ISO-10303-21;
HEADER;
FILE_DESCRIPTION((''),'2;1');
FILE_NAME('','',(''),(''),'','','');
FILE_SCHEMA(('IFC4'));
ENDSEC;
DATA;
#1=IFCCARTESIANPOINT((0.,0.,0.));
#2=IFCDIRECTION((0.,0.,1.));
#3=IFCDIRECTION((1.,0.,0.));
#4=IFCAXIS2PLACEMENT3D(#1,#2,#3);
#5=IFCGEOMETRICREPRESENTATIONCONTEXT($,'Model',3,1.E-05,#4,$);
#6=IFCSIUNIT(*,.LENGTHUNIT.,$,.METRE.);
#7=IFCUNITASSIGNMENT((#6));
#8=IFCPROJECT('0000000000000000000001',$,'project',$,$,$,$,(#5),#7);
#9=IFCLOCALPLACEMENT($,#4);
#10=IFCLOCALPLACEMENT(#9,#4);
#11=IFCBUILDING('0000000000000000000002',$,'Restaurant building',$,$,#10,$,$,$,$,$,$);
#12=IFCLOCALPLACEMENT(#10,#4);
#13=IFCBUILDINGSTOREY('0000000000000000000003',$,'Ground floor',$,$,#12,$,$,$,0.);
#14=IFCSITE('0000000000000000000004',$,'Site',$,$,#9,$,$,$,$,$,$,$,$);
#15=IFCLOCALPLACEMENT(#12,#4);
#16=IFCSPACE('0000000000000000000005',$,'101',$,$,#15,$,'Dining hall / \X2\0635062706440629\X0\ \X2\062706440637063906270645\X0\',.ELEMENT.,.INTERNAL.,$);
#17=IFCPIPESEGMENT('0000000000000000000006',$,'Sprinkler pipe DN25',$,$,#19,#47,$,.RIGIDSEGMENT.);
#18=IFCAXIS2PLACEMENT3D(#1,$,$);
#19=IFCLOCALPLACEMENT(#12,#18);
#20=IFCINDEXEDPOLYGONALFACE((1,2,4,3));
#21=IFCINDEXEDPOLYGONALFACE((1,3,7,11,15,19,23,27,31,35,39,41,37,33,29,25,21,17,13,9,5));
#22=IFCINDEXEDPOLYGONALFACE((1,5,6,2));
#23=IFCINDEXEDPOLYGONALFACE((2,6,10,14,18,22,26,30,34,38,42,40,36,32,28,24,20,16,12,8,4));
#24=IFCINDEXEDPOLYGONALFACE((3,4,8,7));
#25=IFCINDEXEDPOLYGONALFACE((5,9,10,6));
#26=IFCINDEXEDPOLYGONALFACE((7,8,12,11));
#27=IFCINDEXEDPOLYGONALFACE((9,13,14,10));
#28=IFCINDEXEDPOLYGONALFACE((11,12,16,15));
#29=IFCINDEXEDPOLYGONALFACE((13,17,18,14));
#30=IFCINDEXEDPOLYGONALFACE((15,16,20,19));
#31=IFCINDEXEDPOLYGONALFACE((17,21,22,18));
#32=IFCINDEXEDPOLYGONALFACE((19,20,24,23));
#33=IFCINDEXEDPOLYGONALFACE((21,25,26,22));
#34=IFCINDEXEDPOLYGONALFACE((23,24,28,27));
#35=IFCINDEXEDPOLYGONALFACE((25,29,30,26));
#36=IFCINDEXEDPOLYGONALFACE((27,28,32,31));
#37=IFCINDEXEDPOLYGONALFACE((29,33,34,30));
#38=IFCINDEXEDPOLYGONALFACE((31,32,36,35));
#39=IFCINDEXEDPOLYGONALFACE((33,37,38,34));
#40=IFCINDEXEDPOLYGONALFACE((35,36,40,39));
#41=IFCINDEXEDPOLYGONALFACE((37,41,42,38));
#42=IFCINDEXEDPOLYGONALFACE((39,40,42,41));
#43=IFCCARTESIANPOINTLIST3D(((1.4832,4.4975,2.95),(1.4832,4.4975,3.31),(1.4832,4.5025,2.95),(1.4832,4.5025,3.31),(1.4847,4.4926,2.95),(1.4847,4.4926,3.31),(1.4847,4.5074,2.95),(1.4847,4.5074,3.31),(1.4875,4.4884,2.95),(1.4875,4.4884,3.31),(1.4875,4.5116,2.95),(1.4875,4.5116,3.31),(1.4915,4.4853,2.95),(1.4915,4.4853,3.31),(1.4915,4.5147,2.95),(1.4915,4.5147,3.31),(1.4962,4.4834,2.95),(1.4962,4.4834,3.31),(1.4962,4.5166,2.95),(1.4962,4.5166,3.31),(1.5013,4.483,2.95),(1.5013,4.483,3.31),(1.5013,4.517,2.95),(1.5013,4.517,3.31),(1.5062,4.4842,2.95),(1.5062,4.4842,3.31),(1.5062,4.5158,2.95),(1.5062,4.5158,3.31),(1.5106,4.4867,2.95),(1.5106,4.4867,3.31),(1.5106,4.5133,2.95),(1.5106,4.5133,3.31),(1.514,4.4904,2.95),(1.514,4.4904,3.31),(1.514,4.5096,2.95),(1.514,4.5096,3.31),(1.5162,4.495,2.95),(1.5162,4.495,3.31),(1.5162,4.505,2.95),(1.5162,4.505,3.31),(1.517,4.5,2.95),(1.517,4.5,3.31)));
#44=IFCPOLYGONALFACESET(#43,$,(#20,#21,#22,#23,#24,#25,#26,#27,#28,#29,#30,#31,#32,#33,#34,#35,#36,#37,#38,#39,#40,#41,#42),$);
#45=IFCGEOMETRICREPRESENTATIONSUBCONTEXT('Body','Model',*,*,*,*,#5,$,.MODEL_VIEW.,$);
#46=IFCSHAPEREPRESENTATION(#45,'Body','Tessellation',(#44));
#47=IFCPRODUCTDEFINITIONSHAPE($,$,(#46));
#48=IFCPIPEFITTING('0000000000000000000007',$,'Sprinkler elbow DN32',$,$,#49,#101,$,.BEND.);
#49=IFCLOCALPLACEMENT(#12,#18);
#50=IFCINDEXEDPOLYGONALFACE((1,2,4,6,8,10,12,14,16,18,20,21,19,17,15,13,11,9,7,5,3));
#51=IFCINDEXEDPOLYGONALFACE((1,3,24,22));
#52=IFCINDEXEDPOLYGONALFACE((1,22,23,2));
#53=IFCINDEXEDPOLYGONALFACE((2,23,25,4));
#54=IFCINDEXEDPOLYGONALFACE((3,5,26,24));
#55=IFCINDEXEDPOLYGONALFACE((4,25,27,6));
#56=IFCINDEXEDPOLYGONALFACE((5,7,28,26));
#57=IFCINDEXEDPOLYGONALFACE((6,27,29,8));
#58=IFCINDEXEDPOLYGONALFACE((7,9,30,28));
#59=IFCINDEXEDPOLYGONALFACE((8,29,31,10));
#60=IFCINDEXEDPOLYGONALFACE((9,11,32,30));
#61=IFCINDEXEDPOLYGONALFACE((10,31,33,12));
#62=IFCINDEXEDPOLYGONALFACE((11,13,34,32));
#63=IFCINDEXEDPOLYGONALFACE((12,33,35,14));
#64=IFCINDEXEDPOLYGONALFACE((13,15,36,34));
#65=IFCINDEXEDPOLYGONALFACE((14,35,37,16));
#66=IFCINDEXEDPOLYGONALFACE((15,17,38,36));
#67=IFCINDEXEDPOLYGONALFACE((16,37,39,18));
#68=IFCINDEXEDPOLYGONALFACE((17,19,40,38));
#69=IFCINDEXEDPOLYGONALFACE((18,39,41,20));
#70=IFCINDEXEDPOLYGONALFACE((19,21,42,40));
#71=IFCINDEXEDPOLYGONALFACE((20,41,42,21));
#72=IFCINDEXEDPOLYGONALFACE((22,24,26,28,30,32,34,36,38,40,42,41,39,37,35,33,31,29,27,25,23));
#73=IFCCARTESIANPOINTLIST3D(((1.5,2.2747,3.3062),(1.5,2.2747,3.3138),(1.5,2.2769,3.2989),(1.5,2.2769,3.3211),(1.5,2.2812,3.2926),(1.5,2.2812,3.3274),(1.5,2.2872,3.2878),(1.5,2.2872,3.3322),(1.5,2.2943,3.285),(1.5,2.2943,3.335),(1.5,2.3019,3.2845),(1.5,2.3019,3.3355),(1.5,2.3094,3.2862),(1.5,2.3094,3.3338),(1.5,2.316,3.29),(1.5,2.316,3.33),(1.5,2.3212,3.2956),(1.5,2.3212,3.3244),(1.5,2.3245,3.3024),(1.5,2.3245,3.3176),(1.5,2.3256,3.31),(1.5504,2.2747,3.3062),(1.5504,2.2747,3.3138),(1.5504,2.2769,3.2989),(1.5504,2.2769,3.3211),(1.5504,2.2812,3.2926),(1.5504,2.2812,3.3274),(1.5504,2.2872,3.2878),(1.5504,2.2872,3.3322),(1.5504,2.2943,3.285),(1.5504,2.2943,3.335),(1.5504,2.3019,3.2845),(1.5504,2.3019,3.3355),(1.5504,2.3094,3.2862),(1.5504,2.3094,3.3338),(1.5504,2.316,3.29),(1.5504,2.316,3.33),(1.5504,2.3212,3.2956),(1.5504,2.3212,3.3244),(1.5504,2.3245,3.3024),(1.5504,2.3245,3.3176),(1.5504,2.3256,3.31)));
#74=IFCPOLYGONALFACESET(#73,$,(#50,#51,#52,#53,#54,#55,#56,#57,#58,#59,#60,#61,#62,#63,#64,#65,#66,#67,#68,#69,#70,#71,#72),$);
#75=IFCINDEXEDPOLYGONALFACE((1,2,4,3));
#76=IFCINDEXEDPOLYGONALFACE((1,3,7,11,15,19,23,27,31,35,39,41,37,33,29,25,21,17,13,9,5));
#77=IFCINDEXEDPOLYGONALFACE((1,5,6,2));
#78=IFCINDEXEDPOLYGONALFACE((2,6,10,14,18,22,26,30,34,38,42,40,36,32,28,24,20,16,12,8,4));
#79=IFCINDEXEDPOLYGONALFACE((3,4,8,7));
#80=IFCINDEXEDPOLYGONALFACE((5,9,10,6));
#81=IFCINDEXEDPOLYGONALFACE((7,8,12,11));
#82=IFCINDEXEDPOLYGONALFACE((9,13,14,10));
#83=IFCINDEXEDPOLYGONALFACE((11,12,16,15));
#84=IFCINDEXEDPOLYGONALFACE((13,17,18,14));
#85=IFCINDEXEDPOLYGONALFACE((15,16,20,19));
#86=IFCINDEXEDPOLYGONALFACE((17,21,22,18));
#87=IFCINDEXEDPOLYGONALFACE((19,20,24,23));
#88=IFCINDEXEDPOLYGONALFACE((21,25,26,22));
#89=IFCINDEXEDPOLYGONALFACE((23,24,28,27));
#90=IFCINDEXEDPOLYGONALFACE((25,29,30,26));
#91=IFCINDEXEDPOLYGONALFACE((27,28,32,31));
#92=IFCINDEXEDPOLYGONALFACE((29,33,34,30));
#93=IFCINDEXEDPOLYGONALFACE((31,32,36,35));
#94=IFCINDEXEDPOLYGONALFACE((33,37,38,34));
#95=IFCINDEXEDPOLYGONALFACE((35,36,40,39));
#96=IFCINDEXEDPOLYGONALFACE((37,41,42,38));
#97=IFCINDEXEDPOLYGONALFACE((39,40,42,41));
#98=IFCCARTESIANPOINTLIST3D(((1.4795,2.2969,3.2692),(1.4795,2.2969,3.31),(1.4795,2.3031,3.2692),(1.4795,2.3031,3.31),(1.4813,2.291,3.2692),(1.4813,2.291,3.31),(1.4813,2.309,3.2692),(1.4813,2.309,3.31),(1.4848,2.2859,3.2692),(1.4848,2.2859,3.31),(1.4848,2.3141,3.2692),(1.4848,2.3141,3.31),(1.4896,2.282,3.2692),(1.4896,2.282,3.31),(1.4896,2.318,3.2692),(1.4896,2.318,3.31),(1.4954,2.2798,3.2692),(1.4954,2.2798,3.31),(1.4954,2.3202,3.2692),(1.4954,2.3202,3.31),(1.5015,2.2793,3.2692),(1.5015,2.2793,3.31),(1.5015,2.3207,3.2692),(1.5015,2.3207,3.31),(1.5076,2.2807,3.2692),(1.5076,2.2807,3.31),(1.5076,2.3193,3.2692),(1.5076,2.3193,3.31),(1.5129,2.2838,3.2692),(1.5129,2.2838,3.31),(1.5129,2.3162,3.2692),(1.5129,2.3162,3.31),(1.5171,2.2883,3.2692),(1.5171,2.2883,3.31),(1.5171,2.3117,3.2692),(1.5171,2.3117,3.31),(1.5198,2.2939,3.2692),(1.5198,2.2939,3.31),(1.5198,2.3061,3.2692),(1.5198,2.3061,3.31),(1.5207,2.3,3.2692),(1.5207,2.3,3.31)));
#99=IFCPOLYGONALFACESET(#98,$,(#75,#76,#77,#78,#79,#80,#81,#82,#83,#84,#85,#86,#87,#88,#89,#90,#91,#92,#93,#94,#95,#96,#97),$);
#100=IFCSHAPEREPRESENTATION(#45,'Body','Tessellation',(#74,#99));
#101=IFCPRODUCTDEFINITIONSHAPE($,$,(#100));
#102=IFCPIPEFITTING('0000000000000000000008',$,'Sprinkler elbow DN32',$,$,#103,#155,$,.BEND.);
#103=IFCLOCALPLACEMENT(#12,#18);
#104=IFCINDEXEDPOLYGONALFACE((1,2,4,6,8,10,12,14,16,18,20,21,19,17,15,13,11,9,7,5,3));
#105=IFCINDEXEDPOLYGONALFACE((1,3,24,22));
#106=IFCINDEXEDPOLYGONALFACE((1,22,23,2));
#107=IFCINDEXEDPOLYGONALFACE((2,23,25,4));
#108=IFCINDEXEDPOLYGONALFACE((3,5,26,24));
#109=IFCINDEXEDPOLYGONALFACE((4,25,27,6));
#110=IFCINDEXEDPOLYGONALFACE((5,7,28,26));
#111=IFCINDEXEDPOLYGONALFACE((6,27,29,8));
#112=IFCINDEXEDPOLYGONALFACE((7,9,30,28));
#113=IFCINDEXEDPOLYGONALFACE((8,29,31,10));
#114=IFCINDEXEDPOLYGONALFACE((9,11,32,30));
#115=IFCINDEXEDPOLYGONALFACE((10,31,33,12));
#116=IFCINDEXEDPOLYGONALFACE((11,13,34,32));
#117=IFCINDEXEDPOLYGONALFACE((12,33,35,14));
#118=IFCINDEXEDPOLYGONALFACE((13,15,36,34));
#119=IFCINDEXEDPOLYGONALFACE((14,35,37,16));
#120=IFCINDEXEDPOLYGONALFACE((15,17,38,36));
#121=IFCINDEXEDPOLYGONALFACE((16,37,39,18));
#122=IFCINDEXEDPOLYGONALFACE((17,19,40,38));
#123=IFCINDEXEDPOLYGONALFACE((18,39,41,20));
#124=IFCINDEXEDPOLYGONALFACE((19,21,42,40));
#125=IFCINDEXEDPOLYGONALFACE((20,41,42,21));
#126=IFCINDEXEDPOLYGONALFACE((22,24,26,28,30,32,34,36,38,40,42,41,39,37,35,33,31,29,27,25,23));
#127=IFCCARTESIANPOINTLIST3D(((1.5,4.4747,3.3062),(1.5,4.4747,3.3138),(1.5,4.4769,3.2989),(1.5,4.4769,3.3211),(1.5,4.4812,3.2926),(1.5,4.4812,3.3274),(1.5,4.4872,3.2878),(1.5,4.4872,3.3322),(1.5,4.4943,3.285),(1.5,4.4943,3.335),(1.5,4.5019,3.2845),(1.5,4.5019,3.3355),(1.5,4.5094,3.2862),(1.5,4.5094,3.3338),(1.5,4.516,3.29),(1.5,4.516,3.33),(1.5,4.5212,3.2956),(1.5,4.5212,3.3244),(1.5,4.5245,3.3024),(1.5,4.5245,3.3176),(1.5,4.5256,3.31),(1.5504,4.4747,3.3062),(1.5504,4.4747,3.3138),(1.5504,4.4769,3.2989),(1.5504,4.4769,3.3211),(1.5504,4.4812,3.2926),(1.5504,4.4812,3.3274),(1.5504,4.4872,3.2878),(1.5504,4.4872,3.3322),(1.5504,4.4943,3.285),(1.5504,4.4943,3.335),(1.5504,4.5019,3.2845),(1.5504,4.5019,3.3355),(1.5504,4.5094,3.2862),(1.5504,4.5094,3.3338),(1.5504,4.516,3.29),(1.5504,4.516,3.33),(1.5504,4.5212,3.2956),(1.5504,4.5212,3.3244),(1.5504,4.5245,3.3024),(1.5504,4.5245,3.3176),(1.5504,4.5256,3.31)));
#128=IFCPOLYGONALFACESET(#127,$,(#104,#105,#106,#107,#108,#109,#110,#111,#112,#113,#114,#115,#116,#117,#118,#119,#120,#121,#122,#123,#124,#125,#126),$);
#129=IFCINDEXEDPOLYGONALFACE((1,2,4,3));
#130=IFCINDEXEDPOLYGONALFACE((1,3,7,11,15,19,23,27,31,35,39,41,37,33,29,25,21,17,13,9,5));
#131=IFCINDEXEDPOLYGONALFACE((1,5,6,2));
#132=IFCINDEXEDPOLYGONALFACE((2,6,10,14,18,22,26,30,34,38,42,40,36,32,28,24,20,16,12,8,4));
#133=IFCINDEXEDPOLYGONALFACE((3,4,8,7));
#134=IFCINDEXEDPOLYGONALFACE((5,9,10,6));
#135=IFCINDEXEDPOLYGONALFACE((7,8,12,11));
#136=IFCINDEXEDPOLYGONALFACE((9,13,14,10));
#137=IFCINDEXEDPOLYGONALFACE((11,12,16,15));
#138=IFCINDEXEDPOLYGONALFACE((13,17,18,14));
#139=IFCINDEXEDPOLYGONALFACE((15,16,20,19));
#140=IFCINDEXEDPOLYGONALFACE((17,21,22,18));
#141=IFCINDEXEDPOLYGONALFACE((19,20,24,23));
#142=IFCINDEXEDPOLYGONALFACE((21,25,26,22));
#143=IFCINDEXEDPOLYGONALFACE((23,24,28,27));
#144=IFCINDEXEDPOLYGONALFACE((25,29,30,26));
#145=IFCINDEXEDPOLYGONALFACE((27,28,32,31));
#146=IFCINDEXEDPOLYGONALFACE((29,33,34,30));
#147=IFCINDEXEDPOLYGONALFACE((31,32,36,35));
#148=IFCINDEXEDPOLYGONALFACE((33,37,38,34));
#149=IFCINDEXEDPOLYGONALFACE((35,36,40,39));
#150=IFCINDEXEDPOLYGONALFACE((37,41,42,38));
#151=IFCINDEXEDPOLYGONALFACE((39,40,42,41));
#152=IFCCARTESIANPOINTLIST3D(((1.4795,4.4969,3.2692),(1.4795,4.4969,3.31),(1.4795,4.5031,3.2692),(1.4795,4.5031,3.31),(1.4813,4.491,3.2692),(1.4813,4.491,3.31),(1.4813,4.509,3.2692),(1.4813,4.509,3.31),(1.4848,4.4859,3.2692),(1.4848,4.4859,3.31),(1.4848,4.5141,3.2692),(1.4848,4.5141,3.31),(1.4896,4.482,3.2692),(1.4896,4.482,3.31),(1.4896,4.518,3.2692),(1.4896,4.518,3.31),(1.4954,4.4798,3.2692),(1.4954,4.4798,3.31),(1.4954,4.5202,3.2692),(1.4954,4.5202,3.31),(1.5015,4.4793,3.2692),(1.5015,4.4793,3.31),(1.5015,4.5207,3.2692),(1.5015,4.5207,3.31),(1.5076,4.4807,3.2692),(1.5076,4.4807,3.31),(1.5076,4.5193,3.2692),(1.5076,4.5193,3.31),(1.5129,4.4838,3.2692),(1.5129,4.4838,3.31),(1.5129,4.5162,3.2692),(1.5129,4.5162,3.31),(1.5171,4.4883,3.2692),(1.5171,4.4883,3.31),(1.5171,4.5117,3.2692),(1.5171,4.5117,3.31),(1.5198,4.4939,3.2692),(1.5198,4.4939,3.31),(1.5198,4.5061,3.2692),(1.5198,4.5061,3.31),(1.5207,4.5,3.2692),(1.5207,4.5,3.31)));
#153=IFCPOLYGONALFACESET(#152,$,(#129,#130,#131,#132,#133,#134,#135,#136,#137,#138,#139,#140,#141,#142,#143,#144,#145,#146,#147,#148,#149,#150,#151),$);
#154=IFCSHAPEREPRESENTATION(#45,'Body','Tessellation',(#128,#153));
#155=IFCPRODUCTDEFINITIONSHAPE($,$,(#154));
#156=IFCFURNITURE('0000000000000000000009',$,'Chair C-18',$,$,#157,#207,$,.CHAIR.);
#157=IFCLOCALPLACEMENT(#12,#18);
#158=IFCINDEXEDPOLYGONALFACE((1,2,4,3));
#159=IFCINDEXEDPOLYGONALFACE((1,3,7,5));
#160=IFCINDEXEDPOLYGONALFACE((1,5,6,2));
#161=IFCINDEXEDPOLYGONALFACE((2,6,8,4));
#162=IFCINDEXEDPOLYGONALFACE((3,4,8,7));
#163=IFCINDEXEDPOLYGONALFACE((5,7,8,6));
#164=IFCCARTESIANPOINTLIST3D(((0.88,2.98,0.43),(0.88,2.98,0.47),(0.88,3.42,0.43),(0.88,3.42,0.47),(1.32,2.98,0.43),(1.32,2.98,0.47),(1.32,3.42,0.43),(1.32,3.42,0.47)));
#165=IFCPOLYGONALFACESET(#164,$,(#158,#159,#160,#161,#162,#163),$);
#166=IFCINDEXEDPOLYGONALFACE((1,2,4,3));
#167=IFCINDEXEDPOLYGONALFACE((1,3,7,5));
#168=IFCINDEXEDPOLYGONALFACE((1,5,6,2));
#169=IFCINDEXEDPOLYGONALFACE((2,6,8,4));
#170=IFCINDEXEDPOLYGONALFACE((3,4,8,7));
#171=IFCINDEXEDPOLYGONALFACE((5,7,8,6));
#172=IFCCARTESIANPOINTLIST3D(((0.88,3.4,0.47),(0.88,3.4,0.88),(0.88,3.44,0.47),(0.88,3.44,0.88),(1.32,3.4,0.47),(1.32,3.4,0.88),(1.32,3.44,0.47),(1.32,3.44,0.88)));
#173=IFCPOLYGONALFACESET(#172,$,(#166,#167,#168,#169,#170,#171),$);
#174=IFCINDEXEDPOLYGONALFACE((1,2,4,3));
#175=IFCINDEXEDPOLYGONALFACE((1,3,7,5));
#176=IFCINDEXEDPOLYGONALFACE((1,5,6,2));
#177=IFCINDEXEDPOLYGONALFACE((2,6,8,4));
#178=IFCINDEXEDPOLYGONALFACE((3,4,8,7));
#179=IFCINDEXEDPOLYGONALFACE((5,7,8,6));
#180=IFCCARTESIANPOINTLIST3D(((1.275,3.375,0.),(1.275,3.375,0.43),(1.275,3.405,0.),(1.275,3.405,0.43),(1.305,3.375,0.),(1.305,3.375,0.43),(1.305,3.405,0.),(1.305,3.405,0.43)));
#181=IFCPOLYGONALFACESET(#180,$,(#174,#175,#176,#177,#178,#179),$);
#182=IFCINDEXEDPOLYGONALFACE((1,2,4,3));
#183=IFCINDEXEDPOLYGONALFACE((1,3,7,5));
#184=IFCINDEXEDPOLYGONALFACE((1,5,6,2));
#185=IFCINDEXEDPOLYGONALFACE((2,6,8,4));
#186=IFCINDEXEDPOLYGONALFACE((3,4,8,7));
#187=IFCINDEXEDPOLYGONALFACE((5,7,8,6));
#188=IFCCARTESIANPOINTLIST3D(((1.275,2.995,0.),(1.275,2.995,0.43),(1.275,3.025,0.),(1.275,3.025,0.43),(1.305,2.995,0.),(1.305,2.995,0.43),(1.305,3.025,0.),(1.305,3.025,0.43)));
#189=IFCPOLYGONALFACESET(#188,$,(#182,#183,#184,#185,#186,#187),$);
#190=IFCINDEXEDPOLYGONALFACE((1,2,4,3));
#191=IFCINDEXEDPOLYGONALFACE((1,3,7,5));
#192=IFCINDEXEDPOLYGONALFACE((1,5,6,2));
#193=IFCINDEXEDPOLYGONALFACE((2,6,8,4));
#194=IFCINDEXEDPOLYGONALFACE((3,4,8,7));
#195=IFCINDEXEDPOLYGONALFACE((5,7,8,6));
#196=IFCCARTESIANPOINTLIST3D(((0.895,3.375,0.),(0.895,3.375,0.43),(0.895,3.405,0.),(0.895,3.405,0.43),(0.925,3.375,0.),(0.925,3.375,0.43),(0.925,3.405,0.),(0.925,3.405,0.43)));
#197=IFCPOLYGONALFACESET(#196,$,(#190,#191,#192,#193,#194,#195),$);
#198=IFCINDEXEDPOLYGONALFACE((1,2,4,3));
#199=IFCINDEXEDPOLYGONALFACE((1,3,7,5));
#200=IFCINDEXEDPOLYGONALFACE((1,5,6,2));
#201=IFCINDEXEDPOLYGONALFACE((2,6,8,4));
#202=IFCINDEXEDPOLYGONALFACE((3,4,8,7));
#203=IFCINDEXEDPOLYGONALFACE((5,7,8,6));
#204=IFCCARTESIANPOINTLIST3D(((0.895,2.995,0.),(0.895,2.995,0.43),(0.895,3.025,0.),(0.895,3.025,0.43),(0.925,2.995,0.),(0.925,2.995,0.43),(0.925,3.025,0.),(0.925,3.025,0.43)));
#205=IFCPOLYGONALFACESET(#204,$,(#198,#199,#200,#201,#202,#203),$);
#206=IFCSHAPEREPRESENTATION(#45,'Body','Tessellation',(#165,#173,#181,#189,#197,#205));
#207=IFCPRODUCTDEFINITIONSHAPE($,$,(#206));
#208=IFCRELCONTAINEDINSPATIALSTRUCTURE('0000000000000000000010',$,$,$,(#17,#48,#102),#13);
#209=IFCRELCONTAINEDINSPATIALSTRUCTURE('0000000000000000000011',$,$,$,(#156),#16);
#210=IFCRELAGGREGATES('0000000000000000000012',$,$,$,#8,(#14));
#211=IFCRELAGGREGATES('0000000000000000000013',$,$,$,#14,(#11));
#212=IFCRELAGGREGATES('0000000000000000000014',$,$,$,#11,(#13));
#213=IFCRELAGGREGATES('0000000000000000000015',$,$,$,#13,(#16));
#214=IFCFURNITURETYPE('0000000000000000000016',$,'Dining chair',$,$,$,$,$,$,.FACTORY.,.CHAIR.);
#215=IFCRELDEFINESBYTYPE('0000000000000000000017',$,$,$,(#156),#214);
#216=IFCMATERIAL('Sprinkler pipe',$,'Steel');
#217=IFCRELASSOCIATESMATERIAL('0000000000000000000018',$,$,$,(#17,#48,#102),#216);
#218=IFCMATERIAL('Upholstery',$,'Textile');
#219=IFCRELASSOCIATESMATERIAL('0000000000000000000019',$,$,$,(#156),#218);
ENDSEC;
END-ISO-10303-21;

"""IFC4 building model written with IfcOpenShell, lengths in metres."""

from ifc_helpers import new_model, si_unit, frame, origin, origin_with_axes, origin_2d, place, context, subcontext, project, spatial, rectangle, circle, extrude, source, transform, mapped, material, type_object, type_shapes, element, save


model = new_model("IFC4")

# Units and contexts
model_context = context("Model", 3, precision=1e-05, world=origin_with_axes())
body_context = subcontext(model_context, "Body", "Model", "MODEL_VIEW")
ifc_project = project(units=[si_unit("LENGTHUNIT", "METRE")], contexts=[model_context])

# Site, building, storey
site_placement = place(None, origin_with_axes())
site = spatial("IfcSite", under=ifc_project, at=site_placement, Name="Site")
building_placement = place(site_placement, origin_with_axes())
building = spatial("IfcBuilding", under=site, at=building_placement, Name="Restaurant building")
storey_placement = place(building_placement, origin_with_axes())
storey = spatial("IfcBuildingStorey", under=building, at=storey_placement, Name="Ground floor", Elevation=0.0)

# Shared definitions
space_placement = place(storey_placement, origin_with_axes())
space = spatial("IfcSpace", under=storey, at=space_placement, Name="101", LongName="Dining hall / صالة الطعام", CompositionType="ELEMENT", PredefinedType="INTERNAL")

# Pipe segment
ifc_material_1 = material(Name="Sprinkler pipe", Category="Steel")
for number, where, name in (
    (1, (1.5, 4.5, 3.31), "Sprinkler pipe DN25"),
):
    element("IfcPipeSegment", number, at=place(storey_placement, frame(where)), inside=storey, material=ifc_material_1, Name=name, PredefinedType="RIGIDSEGMENT", context=body_context, shape_type="SweptSolid", body=[
        extrude(circle(Radius=0.017, at=origin_2d()), frame((0.0, 0.0, 0.0), z_axis=(0.0, 0.0, -1.0), x_axis=(1.0, 0.0, 0.0)), (0.0, 0.0, 1.0), 0.36),
    ])

# Pipe fittings
for number, where, name in (
    (2, (1.5, 2.3, 3.31), "Sprinkler elbow DN32"),
    (3, (1.5, 4.5, 3.31), "Sprinkler elbow DN32"),
):
    element("IfcPipeFitting", number, at=place(storey_placement, frame(where)), inside=storey, material=ifc_material_1, Name=name, PredefinedType="BEND", context=body_context, shape_type="SweptSolid", body=[
        extrude(circle(Radius=0.0256, at=origin_2d()), frame((0.0, 0.0, 0.0), z_axis=(1.0, 0.0, 0.0), x_axis=(0.0, 1.0, 0.0)), (0.0, 0.0, 1.0), 0.0504),
        extrude(circle(Radius=0.0207, at=origin_2d()), frame((0.0, 0.0, 0.0), z_axis=(0.0, 0.0, -1.0), x_axis=(1.0, 0.0, 0.0)), (0.0, 0.0, 1.0), 0.0408),
    ])

# Furniture
ifc_material_2 = material(Name="Upholstery", Category="Textile")
furniture_type_1 = type_object("IfcFurnitureType", Name="Dining chair", AssemblyPlace="FACTORY", PredefinedType="CHAIR")
shared_shape_1 = source(origin(), body_context, "Body", "SweptSolid", [
    extrude(rectangle(XDim=0.44, YDim=0.44, at=origin_2d()), frame((0.0, 0.0, 0.43)), (0.0, 0.0, 1.0), 0.04),
    extrude(rectangle(XDim=0.44, YDim=0.04, at=origin_2d()), frame((0.0, -0.22, 0.47)), (0.0, 0.0, 1.0), 0.41),
    extrude(rectangle(XDim=0.03, YDim=0.03, at=origin_2d()), frame((-0.19, -0.19, 0.0)), (0.0, 0.0, 1.0), 0.43),
    extrude(rectangle(XDim=0.03, YDim=0.03, at=origin_2d()), frame((-0.19, 0.19, 0.0)), (0.0, 0.0, 1.0), 0.43),
    extrude(rectangle(XDim=0.03, YDim=0.03, at=origin_2d()), frame((0.19, -0.19, 0.0)), (0.0, 0.0, 1.0), 0.43),
    extrude(rectangle(XDim=0.03, YDim=0.03, at=origin_2d()), frame((0.19, 0.19, 0.0)), (0.0, 0.0, 1.0), 0.43),
])
type_shapes(furniture_type_1, [shared_shape_1])
for number, where, z_axis, x_axis, name in (
    (4, (1.1, 3.2, 0.0), (0.0, 0.0, 1.0), (-1.0, 0.0, 0.0), "Chair C-18"),
):
    element("IfcFurniture", number, at=place(storey_placement, frame(where, z_axis=z_axis, x_axis=x_axis)), inside=space, type_object=furniture_type_1, material=ifc_material_2, Name=name, PredefinedType="CHAIR", context=body_context, shape_type="MappedRepresentation", body=[
        mapped(shared_shape_1, transform((0.0, 0.0, 0.0))),
    ])

save(model, "model.ifc")
